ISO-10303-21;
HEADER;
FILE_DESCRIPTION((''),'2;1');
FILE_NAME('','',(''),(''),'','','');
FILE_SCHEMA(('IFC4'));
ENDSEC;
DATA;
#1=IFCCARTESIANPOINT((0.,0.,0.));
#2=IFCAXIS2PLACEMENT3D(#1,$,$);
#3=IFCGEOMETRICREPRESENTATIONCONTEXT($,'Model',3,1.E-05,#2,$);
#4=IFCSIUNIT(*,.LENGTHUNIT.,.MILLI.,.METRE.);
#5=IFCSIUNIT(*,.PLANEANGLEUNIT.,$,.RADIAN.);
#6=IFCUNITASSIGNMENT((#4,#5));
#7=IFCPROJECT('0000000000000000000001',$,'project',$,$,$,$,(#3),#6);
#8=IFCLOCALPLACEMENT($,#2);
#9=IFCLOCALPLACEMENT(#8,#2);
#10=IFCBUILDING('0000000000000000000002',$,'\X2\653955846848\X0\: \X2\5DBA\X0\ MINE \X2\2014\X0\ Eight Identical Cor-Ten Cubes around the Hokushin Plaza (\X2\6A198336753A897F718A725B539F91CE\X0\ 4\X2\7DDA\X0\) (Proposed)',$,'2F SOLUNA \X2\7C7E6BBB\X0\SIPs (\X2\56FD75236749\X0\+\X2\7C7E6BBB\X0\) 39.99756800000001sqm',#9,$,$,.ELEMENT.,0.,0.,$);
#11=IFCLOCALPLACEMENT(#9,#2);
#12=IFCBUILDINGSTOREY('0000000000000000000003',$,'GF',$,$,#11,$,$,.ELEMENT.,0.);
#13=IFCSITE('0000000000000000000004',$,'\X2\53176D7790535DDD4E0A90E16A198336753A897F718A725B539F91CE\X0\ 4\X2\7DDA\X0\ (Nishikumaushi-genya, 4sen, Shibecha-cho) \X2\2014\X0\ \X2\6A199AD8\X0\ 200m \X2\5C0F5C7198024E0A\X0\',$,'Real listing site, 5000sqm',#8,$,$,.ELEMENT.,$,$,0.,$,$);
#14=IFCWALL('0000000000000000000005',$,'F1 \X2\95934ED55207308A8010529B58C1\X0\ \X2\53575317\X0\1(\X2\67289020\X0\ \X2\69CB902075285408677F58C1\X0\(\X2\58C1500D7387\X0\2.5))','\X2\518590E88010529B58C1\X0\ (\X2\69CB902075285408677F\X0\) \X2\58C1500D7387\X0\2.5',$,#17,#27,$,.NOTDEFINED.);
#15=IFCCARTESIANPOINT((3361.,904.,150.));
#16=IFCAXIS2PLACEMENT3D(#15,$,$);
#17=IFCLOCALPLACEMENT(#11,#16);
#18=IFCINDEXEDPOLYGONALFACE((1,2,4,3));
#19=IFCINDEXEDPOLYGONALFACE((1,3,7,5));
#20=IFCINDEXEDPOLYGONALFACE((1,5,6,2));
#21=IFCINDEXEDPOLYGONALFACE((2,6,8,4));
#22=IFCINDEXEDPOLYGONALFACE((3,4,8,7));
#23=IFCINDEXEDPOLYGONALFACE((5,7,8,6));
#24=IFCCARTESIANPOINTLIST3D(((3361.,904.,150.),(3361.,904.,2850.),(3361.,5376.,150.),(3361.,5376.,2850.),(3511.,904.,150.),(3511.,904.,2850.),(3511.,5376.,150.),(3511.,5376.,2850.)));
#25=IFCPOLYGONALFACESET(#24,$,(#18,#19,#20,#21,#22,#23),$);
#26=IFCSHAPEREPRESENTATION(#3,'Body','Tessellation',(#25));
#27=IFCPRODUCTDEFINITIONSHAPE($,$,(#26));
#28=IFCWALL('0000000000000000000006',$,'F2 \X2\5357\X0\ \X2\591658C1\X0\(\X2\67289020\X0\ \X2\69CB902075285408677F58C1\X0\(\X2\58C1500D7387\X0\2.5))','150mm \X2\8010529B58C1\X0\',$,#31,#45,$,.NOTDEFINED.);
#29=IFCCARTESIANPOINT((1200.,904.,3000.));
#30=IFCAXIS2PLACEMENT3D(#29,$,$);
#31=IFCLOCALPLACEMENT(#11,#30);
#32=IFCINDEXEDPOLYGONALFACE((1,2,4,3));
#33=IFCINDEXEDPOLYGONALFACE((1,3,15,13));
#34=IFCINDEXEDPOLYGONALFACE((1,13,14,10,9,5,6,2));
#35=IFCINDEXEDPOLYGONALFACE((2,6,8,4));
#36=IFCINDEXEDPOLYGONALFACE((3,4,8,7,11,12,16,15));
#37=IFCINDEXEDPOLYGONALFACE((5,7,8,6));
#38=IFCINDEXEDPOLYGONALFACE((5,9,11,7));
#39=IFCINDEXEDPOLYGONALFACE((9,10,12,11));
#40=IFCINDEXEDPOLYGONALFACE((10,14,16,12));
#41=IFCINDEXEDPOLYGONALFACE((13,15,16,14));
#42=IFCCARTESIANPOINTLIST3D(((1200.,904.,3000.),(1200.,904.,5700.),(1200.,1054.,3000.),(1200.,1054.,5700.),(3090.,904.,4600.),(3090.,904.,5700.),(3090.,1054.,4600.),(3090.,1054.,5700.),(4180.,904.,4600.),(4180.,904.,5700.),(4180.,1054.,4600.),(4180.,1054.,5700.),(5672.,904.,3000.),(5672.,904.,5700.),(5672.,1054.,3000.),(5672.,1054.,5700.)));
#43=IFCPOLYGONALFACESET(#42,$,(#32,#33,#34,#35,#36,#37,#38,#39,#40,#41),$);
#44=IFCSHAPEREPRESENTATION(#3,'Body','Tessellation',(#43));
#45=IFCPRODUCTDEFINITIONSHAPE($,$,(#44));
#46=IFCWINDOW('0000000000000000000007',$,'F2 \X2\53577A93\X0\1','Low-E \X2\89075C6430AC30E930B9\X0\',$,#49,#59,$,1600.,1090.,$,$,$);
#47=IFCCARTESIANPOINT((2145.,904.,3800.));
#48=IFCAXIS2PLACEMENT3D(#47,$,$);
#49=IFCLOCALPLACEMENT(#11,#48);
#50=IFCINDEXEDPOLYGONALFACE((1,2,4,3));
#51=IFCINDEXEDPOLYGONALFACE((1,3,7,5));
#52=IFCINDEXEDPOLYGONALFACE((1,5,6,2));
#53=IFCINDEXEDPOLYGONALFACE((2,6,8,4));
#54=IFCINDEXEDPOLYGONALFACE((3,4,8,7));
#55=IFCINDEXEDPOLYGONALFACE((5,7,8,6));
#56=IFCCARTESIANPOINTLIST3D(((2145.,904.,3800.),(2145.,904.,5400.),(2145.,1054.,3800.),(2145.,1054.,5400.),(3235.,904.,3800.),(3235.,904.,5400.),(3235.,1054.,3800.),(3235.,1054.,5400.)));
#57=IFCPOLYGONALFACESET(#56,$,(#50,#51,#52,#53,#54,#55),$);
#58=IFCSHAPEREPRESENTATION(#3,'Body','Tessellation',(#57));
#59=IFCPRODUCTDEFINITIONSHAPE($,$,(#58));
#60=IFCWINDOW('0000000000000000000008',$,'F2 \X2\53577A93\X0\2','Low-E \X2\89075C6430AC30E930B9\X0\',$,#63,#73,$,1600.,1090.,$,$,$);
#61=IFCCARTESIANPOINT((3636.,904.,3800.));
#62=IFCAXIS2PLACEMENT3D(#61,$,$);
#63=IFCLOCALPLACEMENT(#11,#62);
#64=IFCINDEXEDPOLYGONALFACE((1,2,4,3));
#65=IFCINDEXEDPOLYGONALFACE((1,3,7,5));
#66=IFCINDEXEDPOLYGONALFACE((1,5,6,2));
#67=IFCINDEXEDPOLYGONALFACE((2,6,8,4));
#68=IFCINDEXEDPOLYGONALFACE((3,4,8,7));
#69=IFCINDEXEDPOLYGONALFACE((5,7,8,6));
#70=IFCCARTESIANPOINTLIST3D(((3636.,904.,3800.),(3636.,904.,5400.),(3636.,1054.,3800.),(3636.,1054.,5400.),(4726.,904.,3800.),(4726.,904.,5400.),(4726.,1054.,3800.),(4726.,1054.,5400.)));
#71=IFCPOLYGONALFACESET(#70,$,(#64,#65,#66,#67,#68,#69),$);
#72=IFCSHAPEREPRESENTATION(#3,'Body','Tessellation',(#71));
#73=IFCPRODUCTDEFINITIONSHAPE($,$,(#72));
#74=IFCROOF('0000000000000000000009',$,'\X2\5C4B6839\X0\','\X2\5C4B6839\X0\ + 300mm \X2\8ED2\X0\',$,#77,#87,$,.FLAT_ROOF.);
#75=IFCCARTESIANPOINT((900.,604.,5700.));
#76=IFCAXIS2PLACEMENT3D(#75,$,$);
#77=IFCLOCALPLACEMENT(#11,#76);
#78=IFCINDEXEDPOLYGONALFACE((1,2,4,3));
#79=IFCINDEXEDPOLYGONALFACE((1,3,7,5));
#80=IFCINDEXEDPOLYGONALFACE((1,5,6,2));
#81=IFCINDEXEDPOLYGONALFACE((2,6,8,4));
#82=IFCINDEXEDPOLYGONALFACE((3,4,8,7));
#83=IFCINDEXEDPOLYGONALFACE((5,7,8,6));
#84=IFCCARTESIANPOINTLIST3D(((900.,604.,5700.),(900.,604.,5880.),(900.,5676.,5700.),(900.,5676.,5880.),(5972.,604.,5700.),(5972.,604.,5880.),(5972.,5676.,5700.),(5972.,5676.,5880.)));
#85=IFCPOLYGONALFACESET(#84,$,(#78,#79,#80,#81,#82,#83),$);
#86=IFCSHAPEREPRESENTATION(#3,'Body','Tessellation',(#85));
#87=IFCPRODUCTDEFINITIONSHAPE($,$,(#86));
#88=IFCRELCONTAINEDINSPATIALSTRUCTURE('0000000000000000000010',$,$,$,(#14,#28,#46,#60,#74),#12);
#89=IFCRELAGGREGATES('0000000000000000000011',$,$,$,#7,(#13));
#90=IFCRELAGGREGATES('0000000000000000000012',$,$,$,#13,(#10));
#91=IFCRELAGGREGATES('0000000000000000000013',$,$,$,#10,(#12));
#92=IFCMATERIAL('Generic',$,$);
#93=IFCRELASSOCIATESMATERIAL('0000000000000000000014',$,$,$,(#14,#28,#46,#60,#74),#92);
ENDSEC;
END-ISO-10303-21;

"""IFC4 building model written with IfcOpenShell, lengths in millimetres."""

from ifc_helpers import new_model, si_unit, frame, frame_2d, origin, place, context, project, spatial, rectangle, extrude, material, element, fill, save


model = new_model("IFC4")

# Units and contexts
model_context = context("Model", 3, precision=1e-05, world=origin())
ifc_project = project(units=[si_unit("LENGTHUNIT", "METRE", prefix="MILLI"), si_unit("PLANEANGLEUNIT", "RADIAN")], contexts=[model_context])

# Site, building, storey
site_placement = place(None, origin())
site = spatial("IfcSite", under=ifc_project, at=site_placement, Name="北海道川上郡標茶町西熊牛原野 4線 (Nishikumaushi-genya, 4sen, Shibecha-cho) — 標高 200m 小山頂上", ObjectType="Real listing site, 5000sqm", CompositionType="ELEMENT", RefElevation=0.0)
building_placement = place(site_placement, origin())
building = spatial("IfcBuilding", under=site, at=building_placement, Name="改善案: 嶺 MINE — Eight Identical Cor-Ten Cubes around the Hokushin Plaza (標茶町西熊牛原野 4線) (Proposed)", ObjectType="2F SOLUNA 籾殻SIPs (国産杉+籾殻) 39.99756800000001sqm", CompositionType="ELEMENT", ElevationOfRefHeight=0.0, ElevationOfTerrain=0.0)
storey_placement = place(building_placement, origin())
storey = spatial("IfcBuildingStorey", under=building, at=storey_placement, Name="GF", CompositionType="ELEMENT", Elevation=0.0)

# Shared definitions
ifc_material_1 = material(Name="Generic")

# Wall
wall_1_placement = place(storey_placement, frame((3361.0, 904.0, 150.0)))
element("IfcWall", 1, at=wall_1_placement, inside=storey, material=ifc_material_1, Name="F1 間仕切り耐力壁 南北1(木造 構造用合板壁(壁倍率2.5))", Description="内部耐力壁 (構造用合板) 壁倍率2.5", PredefinedType="NOTDEFINED", context=model_context, shape_type="SweptSolid", body=[
    extrude(rectangle(XDim=150.0, YDim=4472.0, at=frame_2d((75.0, 2236.0))), frame((3361.0, 904.0, 150.0)), (0.0, 0.0, 1.0), 2700.0),
])

# Wall, openings, windows
wall_2_placement = place(storey_placement, frame((1200.0, 904.0, 3000.0)))
wall_2 = element("IfcWall", 2, at=wall_2_placement, inside=storey, material=ifc_material_1, Name="F2 南 外壁(木造 構造用合板壁(壁倍率2.5))", Description="150mm 耐力壁", PredefinedType="NOTDEFINED", context=model_context, shape_type="SweptSolid", body=[
    extrude(rectangle(XDim=4472.0, YDim=150.0, at=frame_2d((2236.0, 75.0))), frame((1200.0, 904.0, 3000.0)), (0.0, 0.0, 1.0), 2700.0),
])
opening_1_placement = place(storey_placement, frame((2145.0, 904.0, 3800.0)))
opening_1 = element("IfcOpeningElement", 3, at=opening_1_placement, cuts=wall_2, PredefinedType="NOTDEFINED", context=model_context, shape_type="SweptSolid", body=[
    extrude(rectangle(XDim=1090.0, YDim=150.0, at=frame_2d((545.0, 75.0))), frame((2145.0, 904.0, 3800.0)), (0.0, 0.0, 1.0), 1600.0),
])
opening_2_placement = place(storey_placement, frame((3636.0, 904.0, 3800.0)))
opening_2 = element("IfcOpeningElement", 4, at=opening_2_placement, cuts=wall_2, PredefinedType="NOTDEFINED", context=model_context, shape_type="SweptSolid", body=[
    extrude(rectangle(XDim=1090.0, YDim=150.0, at=frame_2d((545.0, 75.0))), frame((3636.0, 904.0, 3800.0)), (0.0, 0.0, 1.0), 1600.0),
])
window_1_placement = place(storey_placement, frame((2145.0, 904.0, 3800.0)))
window_1 = element("IfcWindow", 5, at=window_1_placement, inside=storey, material=ifc_material_1, Name="F2 南窓1", Description="Low-E 複層ガラス", OverallHeight=1600.0, OverallWidth=1090.0, context=model_context, shape_type="SweptSolid", body=[
    extrude(rectangle(XDim=1090.0, YDim=150.0, at=frame_2d((545.0, 75.0))), frame((2145.0, 904.0, 3800.0)), (0.0, 0.0, 1.0), 1600.0),
])
fill(opening_1, window_1)
window_2_placement = place(storey_placement, frame((3636.0, 904.0, 3800.0)))
window_2 = element("IfcWindow", 6, at=window_2_placement, inside=storey, material=ifc_material_1, Name="F2 南窓2", Description="Low-E 複層ガラス", OverallHeight=1600.0, OverallWidth=1090.0, context=model_context, shape_type="SweptSolid", body=[
    extrude(rectangle(XDim=1090.0, YDim=150.0, at=frame_2d((545.0, 75.0))), frame((3636.0, 904.0, 3800.0)), (0.0, 0.0, 1.0), 1600.0),
])
fill(opening_2, window_2)

# Roof
roof_placement = place(storey_placement, frame((900.0, 604.0, 5700.0)))
element("IfcRoof", 7, at=roof_placement, inside=storey, material=ifc_material_1, Name="屋根", Description="屋根 + 300mm 軒", PredefinedType="FLAT_ROOF", context=model_context, shape_type="SweptSolid", body=[
    extrude(rectangle(XDim=5072.0, YDim=5072.0, at=frame_2d((2536.0, 2536.0))), frame((900.0, 604.0, 5700.0)), (0.0, 0.0, 1.0), 180.0),
])

save(model, "model.ifc")
